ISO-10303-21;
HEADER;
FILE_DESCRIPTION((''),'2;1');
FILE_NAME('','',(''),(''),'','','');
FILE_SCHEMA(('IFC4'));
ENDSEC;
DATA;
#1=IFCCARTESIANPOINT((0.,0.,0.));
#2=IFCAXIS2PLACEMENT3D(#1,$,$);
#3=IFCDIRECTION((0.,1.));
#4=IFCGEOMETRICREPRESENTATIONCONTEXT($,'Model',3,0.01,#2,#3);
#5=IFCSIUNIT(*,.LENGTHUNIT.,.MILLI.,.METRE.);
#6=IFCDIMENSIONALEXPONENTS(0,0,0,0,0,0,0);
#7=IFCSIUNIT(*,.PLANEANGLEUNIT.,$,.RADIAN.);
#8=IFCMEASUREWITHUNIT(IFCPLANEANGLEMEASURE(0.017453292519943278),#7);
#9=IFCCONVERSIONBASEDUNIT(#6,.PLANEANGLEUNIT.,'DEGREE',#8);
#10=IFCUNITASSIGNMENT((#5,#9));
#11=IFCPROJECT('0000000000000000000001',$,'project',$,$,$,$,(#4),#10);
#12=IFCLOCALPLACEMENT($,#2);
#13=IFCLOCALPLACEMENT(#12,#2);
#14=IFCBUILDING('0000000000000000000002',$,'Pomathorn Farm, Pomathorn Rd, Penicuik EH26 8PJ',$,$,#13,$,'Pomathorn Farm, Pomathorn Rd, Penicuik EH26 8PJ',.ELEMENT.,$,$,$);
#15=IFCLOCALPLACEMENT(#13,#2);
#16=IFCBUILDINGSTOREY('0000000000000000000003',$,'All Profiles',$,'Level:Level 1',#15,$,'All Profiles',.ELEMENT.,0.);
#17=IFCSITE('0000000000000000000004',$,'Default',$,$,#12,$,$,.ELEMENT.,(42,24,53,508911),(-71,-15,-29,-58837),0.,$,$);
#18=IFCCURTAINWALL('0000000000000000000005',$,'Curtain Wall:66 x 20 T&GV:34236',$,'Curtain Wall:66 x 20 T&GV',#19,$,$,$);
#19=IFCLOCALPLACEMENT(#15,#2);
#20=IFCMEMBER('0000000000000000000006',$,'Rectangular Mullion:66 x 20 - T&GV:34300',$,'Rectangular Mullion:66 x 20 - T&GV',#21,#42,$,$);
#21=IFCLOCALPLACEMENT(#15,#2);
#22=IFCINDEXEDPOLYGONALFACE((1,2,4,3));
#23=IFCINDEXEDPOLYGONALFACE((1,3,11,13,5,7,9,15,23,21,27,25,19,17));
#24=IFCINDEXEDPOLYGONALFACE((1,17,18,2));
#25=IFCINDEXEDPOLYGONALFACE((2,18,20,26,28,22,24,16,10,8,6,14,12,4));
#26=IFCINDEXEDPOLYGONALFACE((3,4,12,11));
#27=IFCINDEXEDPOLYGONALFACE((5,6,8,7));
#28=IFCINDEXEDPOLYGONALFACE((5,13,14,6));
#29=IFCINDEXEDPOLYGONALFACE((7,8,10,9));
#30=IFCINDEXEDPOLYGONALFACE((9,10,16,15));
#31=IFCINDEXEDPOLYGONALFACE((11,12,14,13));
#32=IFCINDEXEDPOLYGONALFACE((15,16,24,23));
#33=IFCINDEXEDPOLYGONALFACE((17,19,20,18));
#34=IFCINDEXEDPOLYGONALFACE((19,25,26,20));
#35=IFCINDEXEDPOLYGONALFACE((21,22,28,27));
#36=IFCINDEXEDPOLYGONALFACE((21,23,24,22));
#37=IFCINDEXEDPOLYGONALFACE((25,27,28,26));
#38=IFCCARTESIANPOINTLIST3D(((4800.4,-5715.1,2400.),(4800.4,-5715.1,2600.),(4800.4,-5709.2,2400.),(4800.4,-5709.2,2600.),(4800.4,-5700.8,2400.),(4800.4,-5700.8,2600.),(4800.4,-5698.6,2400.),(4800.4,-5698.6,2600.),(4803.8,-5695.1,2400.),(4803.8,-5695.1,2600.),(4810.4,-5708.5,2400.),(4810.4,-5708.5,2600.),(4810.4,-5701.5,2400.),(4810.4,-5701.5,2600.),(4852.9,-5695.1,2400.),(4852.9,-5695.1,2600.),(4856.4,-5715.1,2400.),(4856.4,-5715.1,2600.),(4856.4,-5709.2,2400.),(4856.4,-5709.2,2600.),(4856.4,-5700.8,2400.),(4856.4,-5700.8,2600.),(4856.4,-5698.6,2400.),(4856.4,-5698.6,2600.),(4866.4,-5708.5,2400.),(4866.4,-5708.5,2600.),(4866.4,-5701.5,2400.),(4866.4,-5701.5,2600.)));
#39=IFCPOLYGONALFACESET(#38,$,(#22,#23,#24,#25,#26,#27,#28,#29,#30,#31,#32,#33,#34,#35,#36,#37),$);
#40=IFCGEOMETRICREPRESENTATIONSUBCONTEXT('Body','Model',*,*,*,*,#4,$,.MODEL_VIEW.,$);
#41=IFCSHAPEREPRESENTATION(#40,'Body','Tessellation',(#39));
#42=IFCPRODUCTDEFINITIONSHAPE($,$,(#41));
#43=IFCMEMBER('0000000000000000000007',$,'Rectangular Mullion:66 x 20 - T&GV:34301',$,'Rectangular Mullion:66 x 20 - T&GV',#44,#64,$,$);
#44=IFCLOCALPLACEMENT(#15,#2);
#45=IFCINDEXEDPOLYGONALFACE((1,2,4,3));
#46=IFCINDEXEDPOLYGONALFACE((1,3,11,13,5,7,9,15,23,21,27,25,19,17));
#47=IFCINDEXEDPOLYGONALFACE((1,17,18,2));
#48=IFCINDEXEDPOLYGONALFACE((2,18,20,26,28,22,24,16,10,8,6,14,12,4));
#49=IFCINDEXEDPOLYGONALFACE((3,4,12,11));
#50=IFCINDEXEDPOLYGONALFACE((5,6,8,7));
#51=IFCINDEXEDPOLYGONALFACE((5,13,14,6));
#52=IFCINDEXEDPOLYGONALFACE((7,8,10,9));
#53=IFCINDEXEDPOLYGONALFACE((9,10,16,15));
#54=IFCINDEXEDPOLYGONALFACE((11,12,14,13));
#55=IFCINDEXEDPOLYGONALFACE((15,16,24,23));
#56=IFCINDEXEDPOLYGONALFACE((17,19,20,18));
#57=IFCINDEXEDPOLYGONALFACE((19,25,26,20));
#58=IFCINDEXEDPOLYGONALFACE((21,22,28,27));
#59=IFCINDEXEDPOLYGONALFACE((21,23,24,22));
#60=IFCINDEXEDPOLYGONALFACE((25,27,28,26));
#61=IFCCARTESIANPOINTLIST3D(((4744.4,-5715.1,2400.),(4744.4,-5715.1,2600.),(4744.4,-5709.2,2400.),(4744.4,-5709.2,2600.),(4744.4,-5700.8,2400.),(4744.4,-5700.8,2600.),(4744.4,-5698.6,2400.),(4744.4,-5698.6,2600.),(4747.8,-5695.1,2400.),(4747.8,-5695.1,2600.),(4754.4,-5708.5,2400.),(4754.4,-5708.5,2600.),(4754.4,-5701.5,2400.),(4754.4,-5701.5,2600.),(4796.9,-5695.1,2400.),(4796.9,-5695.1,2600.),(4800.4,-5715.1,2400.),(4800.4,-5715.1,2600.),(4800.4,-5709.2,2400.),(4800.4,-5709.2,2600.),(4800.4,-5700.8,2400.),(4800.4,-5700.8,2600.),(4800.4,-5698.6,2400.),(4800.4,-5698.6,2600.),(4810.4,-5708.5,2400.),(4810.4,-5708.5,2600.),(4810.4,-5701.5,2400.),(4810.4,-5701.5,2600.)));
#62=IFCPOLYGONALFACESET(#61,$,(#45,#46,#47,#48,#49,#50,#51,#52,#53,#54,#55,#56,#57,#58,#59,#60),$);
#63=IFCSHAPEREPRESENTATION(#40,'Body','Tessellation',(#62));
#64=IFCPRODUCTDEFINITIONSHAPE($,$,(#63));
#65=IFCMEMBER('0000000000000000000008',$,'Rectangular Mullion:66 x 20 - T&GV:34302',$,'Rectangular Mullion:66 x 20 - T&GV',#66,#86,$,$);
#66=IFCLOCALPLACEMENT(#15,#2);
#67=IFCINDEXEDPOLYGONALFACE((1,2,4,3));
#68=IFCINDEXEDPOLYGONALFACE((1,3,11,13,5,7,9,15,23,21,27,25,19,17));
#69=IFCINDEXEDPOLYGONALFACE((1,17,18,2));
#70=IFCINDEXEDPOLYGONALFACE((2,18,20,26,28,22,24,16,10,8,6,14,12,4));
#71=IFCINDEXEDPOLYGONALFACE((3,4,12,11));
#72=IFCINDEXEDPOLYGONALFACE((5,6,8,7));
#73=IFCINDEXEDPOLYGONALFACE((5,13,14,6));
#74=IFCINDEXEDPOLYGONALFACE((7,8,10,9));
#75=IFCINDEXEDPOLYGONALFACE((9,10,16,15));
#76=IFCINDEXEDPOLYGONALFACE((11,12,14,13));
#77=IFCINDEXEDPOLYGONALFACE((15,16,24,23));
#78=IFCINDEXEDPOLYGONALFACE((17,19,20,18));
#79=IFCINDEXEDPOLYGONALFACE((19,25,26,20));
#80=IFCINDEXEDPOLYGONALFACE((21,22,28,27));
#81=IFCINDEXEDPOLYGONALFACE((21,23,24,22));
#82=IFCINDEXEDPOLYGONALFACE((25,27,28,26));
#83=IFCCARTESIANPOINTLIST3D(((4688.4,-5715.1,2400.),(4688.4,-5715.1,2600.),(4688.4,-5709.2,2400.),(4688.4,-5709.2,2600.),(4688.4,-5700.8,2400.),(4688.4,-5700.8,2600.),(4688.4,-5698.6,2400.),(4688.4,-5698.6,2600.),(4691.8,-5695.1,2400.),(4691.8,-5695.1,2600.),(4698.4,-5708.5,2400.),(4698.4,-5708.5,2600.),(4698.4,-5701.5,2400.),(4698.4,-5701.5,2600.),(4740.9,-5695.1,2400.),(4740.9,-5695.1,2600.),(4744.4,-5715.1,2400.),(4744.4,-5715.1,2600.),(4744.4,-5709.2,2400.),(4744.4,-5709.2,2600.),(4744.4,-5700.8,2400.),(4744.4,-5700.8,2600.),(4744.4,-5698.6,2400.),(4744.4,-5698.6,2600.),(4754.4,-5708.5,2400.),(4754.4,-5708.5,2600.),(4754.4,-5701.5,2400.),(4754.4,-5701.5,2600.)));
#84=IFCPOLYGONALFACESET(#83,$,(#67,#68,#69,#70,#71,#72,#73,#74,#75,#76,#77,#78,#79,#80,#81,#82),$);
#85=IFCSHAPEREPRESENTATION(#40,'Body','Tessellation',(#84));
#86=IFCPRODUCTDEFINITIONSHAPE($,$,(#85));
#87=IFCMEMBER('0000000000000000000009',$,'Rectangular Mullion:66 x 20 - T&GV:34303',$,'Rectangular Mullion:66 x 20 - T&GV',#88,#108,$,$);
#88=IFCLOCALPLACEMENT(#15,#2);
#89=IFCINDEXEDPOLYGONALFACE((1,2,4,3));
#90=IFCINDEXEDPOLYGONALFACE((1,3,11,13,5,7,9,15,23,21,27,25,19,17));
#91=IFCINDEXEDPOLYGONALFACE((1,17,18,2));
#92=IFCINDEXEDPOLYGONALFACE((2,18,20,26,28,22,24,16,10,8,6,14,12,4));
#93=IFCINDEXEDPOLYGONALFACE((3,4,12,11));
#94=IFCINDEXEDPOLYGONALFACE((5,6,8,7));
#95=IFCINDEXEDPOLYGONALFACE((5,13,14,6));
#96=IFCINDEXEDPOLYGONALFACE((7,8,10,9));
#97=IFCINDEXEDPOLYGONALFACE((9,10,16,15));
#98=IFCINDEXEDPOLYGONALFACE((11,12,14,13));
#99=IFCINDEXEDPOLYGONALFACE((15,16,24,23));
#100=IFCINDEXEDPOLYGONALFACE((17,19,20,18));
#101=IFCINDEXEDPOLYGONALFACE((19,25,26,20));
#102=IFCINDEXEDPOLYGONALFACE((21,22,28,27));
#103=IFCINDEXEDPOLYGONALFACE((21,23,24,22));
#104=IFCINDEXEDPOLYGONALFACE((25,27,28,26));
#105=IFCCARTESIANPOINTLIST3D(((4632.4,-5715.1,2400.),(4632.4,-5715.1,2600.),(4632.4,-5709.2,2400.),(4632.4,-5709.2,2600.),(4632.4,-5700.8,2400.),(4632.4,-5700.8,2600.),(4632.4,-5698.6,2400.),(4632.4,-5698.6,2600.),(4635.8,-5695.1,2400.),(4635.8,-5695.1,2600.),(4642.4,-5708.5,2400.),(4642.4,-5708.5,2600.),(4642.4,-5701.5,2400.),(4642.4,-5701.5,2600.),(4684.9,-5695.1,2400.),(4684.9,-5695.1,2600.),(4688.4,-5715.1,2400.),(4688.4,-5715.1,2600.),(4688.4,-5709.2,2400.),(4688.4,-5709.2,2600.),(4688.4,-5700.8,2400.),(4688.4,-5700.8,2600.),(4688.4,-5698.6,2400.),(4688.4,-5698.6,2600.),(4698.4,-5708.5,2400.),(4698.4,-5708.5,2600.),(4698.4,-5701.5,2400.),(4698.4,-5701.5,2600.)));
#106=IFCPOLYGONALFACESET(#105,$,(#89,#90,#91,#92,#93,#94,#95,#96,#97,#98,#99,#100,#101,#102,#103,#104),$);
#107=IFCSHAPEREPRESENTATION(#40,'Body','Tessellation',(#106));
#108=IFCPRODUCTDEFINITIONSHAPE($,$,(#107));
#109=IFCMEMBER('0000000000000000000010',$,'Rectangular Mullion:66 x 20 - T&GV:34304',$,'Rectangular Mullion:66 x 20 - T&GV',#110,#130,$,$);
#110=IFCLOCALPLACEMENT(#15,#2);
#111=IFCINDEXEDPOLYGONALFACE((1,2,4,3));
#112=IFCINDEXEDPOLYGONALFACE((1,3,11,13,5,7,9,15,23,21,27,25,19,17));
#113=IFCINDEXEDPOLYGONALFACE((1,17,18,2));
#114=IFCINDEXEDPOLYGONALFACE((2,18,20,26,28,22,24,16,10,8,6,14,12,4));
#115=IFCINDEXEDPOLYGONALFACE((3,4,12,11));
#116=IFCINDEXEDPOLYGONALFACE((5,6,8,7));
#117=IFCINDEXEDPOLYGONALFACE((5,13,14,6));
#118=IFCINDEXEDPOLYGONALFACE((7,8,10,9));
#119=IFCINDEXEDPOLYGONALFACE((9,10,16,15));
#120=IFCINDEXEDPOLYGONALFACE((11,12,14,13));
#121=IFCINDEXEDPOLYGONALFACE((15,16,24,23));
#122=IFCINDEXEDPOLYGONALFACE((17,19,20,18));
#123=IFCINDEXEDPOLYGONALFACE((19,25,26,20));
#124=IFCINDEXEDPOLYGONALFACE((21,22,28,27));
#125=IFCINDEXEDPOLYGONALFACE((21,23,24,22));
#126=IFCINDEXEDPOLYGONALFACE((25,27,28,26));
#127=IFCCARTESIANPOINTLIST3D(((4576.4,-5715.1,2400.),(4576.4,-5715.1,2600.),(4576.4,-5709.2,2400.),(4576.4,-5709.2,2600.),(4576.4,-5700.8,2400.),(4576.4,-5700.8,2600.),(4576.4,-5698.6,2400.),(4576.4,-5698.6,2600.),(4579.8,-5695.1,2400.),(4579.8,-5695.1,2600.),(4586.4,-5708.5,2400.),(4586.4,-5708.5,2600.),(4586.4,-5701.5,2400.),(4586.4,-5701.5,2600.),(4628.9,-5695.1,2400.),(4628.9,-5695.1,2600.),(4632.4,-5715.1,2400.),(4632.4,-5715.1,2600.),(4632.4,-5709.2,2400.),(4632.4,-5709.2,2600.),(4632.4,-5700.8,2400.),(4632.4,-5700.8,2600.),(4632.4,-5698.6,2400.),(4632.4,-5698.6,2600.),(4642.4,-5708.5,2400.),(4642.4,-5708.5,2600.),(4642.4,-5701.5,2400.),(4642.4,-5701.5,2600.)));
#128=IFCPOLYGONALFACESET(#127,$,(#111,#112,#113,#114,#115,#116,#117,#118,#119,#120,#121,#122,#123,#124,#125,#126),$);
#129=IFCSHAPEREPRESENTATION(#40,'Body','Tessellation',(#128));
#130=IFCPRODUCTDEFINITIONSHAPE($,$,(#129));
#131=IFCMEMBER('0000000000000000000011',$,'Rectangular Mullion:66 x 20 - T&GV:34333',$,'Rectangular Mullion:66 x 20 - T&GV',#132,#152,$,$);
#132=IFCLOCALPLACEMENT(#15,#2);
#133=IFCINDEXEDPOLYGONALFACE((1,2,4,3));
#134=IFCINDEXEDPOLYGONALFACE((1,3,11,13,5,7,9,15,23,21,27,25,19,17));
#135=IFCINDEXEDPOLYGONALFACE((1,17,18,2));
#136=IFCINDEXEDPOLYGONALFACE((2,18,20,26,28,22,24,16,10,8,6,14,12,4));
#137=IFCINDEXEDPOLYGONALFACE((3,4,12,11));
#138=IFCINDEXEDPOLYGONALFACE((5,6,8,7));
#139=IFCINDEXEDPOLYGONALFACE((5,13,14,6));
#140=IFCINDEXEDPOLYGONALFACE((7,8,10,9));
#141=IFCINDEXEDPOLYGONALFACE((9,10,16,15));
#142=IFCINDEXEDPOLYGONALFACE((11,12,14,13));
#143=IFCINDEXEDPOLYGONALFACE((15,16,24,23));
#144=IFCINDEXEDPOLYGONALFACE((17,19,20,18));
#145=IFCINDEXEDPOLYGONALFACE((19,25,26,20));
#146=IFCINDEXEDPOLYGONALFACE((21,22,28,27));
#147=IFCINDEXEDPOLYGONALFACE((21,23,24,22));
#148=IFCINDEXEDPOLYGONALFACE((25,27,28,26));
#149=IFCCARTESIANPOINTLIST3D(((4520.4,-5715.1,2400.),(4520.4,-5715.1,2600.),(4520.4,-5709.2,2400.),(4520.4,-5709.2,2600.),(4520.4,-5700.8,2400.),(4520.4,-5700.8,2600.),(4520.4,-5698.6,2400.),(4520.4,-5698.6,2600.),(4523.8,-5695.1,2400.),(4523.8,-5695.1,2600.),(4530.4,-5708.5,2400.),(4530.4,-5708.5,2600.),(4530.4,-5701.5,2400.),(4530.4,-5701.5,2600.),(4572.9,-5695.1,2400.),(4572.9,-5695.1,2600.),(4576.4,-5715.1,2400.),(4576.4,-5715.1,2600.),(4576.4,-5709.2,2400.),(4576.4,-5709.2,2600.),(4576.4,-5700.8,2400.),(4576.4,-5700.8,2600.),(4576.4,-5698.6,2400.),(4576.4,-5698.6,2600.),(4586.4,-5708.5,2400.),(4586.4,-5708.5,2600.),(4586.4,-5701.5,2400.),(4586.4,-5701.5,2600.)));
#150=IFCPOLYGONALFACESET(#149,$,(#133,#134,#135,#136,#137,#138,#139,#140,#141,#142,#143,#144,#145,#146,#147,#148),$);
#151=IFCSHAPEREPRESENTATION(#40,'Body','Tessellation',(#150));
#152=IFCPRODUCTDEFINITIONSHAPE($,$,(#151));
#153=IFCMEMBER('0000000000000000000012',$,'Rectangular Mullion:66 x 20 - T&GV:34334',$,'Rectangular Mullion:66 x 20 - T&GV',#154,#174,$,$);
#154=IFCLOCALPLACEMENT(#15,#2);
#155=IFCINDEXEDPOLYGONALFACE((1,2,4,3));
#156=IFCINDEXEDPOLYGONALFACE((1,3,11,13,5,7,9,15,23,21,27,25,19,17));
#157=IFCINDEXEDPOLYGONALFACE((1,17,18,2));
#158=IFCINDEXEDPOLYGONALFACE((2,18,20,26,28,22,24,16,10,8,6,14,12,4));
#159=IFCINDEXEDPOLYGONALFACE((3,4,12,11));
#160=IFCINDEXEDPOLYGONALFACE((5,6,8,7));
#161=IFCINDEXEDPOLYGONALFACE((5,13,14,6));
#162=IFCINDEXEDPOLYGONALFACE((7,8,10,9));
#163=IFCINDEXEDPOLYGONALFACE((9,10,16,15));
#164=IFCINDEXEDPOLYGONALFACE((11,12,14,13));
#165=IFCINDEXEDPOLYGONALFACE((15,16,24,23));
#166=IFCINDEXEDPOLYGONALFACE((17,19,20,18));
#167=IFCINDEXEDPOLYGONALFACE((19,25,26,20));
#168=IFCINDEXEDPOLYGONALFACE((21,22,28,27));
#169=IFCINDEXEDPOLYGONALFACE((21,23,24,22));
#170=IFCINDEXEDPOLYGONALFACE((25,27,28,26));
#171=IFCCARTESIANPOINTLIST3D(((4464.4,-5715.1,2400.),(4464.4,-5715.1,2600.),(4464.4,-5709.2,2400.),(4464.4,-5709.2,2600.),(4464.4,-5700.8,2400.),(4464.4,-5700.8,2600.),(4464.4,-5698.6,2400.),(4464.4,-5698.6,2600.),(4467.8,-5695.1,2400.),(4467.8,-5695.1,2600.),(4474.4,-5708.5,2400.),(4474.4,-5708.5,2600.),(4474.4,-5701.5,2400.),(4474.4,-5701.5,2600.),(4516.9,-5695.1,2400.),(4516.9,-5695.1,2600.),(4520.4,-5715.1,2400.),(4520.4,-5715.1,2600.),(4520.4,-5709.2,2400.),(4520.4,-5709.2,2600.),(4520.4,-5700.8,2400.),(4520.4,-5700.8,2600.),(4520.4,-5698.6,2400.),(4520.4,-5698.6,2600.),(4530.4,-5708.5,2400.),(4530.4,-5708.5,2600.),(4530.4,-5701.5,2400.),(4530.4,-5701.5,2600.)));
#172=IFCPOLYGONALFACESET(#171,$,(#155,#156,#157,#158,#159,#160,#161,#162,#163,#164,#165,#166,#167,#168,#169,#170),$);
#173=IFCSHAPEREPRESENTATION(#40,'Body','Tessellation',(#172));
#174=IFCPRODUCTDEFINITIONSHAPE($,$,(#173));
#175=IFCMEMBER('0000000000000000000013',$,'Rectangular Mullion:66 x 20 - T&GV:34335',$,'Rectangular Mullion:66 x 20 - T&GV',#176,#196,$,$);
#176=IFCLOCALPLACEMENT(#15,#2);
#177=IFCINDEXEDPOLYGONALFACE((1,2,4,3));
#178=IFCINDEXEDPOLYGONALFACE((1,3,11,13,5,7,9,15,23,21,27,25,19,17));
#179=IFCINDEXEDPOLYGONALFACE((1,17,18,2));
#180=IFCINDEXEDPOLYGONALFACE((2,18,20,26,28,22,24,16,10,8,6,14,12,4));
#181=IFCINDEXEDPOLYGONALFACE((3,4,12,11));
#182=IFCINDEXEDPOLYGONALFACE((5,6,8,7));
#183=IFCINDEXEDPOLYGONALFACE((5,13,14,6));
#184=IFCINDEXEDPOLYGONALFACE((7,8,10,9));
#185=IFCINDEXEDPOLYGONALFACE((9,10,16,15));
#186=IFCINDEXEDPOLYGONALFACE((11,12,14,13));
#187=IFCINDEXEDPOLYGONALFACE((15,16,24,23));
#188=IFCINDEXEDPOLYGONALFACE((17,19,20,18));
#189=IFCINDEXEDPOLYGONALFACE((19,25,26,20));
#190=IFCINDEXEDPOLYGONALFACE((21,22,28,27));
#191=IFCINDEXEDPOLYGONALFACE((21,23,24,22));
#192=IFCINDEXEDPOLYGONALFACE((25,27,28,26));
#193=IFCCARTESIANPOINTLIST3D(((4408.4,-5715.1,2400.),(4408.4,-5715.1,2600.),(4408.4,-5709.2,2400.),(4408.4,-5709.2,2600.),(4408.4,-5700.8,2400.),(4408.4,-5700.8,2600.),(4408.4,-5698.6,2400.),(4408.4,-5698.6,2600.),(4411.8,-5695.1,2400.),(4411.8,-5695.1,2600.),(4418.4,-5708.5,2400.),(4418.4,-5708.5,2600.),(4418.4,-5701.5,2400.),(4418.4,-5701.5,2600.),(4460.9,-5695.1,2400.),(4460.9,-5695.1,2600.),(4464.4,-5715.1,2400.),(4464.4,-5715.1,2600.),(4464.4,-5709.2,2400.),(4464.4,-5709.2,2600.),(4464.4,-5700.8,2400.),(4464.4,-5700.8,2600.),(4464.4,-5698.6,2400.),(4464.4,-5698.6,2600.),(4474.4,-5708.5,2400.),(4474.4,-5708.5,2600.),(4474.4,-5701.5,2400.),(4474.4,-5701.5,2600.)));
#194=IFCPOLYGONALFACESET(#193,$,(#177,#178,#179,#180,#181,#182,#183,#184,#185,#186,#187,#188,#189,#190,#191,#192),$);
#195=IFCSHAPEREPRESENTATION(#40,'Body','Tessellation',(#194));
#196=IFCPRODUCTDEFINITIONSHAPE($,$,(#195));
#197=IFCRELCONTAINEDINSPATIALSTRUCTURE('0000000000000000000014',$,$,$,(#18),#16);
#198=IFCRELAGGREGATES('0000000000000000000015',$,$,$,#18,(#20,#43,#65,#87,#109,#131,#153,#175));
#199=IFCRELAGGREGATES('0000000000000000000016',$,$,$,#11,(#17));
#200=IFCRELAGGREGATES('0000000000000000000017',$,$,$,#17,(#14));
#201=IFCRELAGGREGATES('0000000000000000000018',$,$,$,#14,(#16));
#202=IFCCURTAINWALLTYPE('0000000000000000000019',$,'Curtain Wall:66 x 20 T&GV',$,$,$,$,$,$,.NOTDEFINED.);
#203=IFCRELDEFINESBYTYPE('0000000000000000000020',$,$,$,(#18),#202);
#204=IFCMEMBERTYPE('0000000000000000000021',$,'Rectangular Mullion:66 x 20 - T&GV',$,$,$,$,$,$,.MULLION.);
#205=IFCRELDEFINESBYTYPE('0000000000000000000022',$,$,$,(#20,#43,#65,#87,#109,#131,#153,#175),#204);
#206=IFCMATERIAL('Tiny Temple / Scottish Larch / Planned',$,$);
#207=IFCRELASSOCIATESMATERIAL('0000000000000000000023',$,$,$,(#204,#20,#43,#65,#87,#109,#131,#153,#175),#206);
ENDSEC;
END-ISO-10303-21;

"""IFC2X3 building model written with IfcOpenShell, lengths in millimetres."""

from ifc_helpers import new_model, entity, si_unit, converted_unit, direction, frame, origin, place, context, subcontext, project, spatial, polyline, outline, extrude, source, transform, mapped, material, type_object, type_shapes, element, aggregate, save


model = new_model("IFC2X3")

# Units and contexts
model_context = context("Model", 3, precision=0.01, world=origin(), true_north=direction((0.0, 1.0)))
body_context = subcontext(model_context, "Body", "Model", "MODEL_VIEW")
ifc_project = project(units=[si_unit("LENGTHUNIT", "METRE", prefix="MILLI"), converted_unit("PLANEANGLEUNIT", "DEGREE", entity("IfcPlaneAngleMeasure", 0.017453292519943278), si_unit("PLANEANGLEUNIT", "RADIAN"), dimensions=[0, 0, 0, 0, 0, 0, 0])], contexts=[model_context])

# Site, building, storey
site_placement = place(None, origin())
site = spatial("IfcSite", under=ifc_project, at=site_placement, Name="Default", CompositionType="ELEMENT", RefLatitude=(42, 24, 53, 508911), RefLongitude=(-71, -15, -29, -58837), RefElevation=0.0)
building_placement = place(site_placement, origin())
building = spatial("IfcBuilding", under=site, at=building_placement, Name="Pomathorn Farm, Pomathorn Rd, Penicuik EH26 8PJ", LongName="Pomathorn Farm, Pomathorn Rd, Penicuik EH26 8PJ", CompositionType="ELEMENT")
storey_placement = place(building_placement, origin())
storey = spatial("IfcBuildingStorey", under=building, at=storey_placement, Name="All Profiles", ObjectType="Level:Level 1", LongName="All Profiles", CompositionType="ELEMENT", Elevation=0.0)

# Curtain wall, members
curtain_wall_type = type_object("IfcCurtainWallType", Name="Curtain Wall:66 x 20 T&GV", PredefinedType="NOTDEFINED")
curtain_wall_placement = place(storey_placement, origin())
curtain_wall = element("IfcCurtainWall", 1, at=curtain_wall_placement, inside=storey, type_object=curtain_wall_type, Name="Curtain Wall:66 x 20 T&GV:34236", ObjectType="Curtain Wall:66 x 20 T&GV")
ifc_material = material(Name="Tiny Temple / Scottish Larch / Planned")
member_type = type_object("IfcMemberType", Name="Rectangular Mullion:66 x 20 - T&GV", PredefinedType="MULLION", material=ifc_material)
shared_shape = source(origin(), body_context, "Body", "SweptSolid", [
    extrude(outline(polyline([(-25.1, -11.0), (30.9, -11.0), (30.9, -5.1), (20.9, -4.4), (20.9, 2.6), (30.9, 3.3), (30.9, 5.5), (27.4, 9.0), (-21.7, 9.0), (-25.1, 5.5), (-25.1, 3.3), (-35.1, 2.6), (-35.1, -4.4), (-25.1, -5.1), (-25.1, -11.0)])), frame((-35.1, -11.0, -200.0), z_axis=(0.0, 0.0, 1.0), x_axis=(-1.0, 0.0, 0.0)), (0.0, 0.0, 1.0), 200.0),
])
type_shapes(member_type, [shared_shape])
member_1_placement = place(curtain_wall_placement, frame((4866.4, -5715.1, 2400.0), z_axis=(0.0, 0.0, -1.0), x_axis=(1.0, 0.0, 0.0)))
member_1 = element("IfcMember", 2, at=member_1_placement, type_object=member_type, material=ifc_material, Name="Rectangular Mullion:66 x 20 - T&GV:34300", ObjectType="Rectangular Mullion:66 x 20 - T&GV", context=body_context, shape_type="MappedRepresentation", body=[
    mapped(shared_shape, transform((0.0, 0.0, 0.0), scale=1.0)),
])
member_2_placement = place(curtain_wall_placement, frame((4810.4, -5715.1, 2400.0), z_axis=(0.0, 0.0, -1.0), x_axis=(1.0, 0.0, 0.0)))
member_2 = element("IfcMember", 3, at=member_2_placement, type_object=member_type, material=ifc_material, Name="Rectangular Mullion:66 x 20 - T&GV:34301", ObjectType="Rectangular Mullion:66 x 20 - T&GV", context=body_context, shape_type="MappedRepresentation", body=[
    mapped(shared_shape, transform((0.0, 0.0, 0.0), scale=1.0)),
])
member_3_placement = place(curtain_wall_placement, frame((4754.4, -5715.1, 2400.0), z_axis=(0.0, 0.0, -1.0), x_axis=(1.0, 0.0, 0.0)))
member_3 = element("IfcMember", 4, at=member_3_placement, type_object=member_type, material=ifc_material, Name="Rectangular Mullion:66 x 20 - T&GV:34302", ObjectType="Rectangular Mullion:66 x 20 - T&GV", context=body_context, shape_type="MappedRepresentation", body=[
    mapped(shared_shape, transform((0.0, 0.0, 0.0), scale=1.0)),
])
member_4_placement = place(curtain_wall_placement, frame((4698.4, -5715.1, 2400.0), z_axis=(0.0, 0.0, -1.0), x_axis=(1.0, 0.0, 0.0)))
member_4 = element("IfcMember", 5, at=member_4_placement, type_object=member_type, material=ifc_material, Name="Rectangular Mullion:66 x 20 - T&GV:34303", ObjectType="Rectangular Mullion:66 x 20 - T&GV", context=body_context, shape_type="MappedRepresentation", body=[
    mapped(shared_shape, transform((0.0, 0.0, 0.0), scale=1.0)),
])
member_5_placement = place(curtain_wall_placement, frame((4642.4, -5715.1, 2400.0), z_axis=(0.0, 0.0, -1.0), x_axis=(1.0, 0.0, 0.0)))
member_5 = element("IfcMember", 6, at=member_5_placement, type_object=member_type, material=ifc_material, Name="Rectangular Mullion:66 x 20 - T&GV:34304", ObjectType="Rectangular Mullion:66 x 20 - T&GV", context=body_context, shape_type="MappedRepresentation", body=[
    mapped(shared_shape, transform((0.0, 0.0, 0.0), scale=1.0)),
])
member_6_placement = place(curtain_wall_placement, frame((4586.4, -5715.1, 2400.0), z_axis=(0.0, 0.0, -1.0), x_axis=(1.0, 0.0, 0.0)))
member_6 = element("IfcMember", 7, at=member_6_placement, type_object=member_type, material=ifc_material, Name="Rectangular Mullion:66 x 20 - T&GV:34333", ObjectType="Rectangular Mullion:66 x 20 - T&GV", context=body_context, shape_type="MappedRepresentation", body=[
    mapped(shared_shape, transform((0.0, 0.0, 0.0), scale=1.0)),
])
member_7_placement = place(curtain_wall_placement, frame((4530.4, -5715.1, 2400.0), z_axis=(0.0, 0.0, -1.0), x_axis=(1.0, 0.0, 0.0)))
member_7 = element("IfcMember", 8, at=member_7_placement, type_object=member_type, material=ifc_material, Name="Rectangular Mullion:66 x 20 - T&GV:34334", ObjectType="Rectangular Mullion:66 x 20 - T&GV", context=body_context, shape_type="MappedRepresentation", body=[
    mapped(shared_shape, transform((0.0, 0.0, 0.0), scale=1.0)),
])
member_8_placement = place(curtain_wall_placement, frame((4474.4, -5715.1, 2400.0), z_axis=(0.0, 0.0, -1.0), x_axis=(1.0, 0.0, 0.0)))
member_8 = element("IfcMember", 9, at=member_8_placement, type_object=member_type, material=ifc_material, Name="Rectangular Mullion:66 x 20 - T&GV:34335", ObjectType="Rectangular Mullion:66 x 20 - T&GV", context=body_context, shape_type="MappedRepresentation", body=[
    mapped(shared_shape, transform((0.0, 0.0, 0.0), scale=1.0)),
])
aggregate(curtain_wall, [member_1, member_2, member_3, member_4, member_5, member_6, member_7, member_8])

save(model, "model.ifc")
